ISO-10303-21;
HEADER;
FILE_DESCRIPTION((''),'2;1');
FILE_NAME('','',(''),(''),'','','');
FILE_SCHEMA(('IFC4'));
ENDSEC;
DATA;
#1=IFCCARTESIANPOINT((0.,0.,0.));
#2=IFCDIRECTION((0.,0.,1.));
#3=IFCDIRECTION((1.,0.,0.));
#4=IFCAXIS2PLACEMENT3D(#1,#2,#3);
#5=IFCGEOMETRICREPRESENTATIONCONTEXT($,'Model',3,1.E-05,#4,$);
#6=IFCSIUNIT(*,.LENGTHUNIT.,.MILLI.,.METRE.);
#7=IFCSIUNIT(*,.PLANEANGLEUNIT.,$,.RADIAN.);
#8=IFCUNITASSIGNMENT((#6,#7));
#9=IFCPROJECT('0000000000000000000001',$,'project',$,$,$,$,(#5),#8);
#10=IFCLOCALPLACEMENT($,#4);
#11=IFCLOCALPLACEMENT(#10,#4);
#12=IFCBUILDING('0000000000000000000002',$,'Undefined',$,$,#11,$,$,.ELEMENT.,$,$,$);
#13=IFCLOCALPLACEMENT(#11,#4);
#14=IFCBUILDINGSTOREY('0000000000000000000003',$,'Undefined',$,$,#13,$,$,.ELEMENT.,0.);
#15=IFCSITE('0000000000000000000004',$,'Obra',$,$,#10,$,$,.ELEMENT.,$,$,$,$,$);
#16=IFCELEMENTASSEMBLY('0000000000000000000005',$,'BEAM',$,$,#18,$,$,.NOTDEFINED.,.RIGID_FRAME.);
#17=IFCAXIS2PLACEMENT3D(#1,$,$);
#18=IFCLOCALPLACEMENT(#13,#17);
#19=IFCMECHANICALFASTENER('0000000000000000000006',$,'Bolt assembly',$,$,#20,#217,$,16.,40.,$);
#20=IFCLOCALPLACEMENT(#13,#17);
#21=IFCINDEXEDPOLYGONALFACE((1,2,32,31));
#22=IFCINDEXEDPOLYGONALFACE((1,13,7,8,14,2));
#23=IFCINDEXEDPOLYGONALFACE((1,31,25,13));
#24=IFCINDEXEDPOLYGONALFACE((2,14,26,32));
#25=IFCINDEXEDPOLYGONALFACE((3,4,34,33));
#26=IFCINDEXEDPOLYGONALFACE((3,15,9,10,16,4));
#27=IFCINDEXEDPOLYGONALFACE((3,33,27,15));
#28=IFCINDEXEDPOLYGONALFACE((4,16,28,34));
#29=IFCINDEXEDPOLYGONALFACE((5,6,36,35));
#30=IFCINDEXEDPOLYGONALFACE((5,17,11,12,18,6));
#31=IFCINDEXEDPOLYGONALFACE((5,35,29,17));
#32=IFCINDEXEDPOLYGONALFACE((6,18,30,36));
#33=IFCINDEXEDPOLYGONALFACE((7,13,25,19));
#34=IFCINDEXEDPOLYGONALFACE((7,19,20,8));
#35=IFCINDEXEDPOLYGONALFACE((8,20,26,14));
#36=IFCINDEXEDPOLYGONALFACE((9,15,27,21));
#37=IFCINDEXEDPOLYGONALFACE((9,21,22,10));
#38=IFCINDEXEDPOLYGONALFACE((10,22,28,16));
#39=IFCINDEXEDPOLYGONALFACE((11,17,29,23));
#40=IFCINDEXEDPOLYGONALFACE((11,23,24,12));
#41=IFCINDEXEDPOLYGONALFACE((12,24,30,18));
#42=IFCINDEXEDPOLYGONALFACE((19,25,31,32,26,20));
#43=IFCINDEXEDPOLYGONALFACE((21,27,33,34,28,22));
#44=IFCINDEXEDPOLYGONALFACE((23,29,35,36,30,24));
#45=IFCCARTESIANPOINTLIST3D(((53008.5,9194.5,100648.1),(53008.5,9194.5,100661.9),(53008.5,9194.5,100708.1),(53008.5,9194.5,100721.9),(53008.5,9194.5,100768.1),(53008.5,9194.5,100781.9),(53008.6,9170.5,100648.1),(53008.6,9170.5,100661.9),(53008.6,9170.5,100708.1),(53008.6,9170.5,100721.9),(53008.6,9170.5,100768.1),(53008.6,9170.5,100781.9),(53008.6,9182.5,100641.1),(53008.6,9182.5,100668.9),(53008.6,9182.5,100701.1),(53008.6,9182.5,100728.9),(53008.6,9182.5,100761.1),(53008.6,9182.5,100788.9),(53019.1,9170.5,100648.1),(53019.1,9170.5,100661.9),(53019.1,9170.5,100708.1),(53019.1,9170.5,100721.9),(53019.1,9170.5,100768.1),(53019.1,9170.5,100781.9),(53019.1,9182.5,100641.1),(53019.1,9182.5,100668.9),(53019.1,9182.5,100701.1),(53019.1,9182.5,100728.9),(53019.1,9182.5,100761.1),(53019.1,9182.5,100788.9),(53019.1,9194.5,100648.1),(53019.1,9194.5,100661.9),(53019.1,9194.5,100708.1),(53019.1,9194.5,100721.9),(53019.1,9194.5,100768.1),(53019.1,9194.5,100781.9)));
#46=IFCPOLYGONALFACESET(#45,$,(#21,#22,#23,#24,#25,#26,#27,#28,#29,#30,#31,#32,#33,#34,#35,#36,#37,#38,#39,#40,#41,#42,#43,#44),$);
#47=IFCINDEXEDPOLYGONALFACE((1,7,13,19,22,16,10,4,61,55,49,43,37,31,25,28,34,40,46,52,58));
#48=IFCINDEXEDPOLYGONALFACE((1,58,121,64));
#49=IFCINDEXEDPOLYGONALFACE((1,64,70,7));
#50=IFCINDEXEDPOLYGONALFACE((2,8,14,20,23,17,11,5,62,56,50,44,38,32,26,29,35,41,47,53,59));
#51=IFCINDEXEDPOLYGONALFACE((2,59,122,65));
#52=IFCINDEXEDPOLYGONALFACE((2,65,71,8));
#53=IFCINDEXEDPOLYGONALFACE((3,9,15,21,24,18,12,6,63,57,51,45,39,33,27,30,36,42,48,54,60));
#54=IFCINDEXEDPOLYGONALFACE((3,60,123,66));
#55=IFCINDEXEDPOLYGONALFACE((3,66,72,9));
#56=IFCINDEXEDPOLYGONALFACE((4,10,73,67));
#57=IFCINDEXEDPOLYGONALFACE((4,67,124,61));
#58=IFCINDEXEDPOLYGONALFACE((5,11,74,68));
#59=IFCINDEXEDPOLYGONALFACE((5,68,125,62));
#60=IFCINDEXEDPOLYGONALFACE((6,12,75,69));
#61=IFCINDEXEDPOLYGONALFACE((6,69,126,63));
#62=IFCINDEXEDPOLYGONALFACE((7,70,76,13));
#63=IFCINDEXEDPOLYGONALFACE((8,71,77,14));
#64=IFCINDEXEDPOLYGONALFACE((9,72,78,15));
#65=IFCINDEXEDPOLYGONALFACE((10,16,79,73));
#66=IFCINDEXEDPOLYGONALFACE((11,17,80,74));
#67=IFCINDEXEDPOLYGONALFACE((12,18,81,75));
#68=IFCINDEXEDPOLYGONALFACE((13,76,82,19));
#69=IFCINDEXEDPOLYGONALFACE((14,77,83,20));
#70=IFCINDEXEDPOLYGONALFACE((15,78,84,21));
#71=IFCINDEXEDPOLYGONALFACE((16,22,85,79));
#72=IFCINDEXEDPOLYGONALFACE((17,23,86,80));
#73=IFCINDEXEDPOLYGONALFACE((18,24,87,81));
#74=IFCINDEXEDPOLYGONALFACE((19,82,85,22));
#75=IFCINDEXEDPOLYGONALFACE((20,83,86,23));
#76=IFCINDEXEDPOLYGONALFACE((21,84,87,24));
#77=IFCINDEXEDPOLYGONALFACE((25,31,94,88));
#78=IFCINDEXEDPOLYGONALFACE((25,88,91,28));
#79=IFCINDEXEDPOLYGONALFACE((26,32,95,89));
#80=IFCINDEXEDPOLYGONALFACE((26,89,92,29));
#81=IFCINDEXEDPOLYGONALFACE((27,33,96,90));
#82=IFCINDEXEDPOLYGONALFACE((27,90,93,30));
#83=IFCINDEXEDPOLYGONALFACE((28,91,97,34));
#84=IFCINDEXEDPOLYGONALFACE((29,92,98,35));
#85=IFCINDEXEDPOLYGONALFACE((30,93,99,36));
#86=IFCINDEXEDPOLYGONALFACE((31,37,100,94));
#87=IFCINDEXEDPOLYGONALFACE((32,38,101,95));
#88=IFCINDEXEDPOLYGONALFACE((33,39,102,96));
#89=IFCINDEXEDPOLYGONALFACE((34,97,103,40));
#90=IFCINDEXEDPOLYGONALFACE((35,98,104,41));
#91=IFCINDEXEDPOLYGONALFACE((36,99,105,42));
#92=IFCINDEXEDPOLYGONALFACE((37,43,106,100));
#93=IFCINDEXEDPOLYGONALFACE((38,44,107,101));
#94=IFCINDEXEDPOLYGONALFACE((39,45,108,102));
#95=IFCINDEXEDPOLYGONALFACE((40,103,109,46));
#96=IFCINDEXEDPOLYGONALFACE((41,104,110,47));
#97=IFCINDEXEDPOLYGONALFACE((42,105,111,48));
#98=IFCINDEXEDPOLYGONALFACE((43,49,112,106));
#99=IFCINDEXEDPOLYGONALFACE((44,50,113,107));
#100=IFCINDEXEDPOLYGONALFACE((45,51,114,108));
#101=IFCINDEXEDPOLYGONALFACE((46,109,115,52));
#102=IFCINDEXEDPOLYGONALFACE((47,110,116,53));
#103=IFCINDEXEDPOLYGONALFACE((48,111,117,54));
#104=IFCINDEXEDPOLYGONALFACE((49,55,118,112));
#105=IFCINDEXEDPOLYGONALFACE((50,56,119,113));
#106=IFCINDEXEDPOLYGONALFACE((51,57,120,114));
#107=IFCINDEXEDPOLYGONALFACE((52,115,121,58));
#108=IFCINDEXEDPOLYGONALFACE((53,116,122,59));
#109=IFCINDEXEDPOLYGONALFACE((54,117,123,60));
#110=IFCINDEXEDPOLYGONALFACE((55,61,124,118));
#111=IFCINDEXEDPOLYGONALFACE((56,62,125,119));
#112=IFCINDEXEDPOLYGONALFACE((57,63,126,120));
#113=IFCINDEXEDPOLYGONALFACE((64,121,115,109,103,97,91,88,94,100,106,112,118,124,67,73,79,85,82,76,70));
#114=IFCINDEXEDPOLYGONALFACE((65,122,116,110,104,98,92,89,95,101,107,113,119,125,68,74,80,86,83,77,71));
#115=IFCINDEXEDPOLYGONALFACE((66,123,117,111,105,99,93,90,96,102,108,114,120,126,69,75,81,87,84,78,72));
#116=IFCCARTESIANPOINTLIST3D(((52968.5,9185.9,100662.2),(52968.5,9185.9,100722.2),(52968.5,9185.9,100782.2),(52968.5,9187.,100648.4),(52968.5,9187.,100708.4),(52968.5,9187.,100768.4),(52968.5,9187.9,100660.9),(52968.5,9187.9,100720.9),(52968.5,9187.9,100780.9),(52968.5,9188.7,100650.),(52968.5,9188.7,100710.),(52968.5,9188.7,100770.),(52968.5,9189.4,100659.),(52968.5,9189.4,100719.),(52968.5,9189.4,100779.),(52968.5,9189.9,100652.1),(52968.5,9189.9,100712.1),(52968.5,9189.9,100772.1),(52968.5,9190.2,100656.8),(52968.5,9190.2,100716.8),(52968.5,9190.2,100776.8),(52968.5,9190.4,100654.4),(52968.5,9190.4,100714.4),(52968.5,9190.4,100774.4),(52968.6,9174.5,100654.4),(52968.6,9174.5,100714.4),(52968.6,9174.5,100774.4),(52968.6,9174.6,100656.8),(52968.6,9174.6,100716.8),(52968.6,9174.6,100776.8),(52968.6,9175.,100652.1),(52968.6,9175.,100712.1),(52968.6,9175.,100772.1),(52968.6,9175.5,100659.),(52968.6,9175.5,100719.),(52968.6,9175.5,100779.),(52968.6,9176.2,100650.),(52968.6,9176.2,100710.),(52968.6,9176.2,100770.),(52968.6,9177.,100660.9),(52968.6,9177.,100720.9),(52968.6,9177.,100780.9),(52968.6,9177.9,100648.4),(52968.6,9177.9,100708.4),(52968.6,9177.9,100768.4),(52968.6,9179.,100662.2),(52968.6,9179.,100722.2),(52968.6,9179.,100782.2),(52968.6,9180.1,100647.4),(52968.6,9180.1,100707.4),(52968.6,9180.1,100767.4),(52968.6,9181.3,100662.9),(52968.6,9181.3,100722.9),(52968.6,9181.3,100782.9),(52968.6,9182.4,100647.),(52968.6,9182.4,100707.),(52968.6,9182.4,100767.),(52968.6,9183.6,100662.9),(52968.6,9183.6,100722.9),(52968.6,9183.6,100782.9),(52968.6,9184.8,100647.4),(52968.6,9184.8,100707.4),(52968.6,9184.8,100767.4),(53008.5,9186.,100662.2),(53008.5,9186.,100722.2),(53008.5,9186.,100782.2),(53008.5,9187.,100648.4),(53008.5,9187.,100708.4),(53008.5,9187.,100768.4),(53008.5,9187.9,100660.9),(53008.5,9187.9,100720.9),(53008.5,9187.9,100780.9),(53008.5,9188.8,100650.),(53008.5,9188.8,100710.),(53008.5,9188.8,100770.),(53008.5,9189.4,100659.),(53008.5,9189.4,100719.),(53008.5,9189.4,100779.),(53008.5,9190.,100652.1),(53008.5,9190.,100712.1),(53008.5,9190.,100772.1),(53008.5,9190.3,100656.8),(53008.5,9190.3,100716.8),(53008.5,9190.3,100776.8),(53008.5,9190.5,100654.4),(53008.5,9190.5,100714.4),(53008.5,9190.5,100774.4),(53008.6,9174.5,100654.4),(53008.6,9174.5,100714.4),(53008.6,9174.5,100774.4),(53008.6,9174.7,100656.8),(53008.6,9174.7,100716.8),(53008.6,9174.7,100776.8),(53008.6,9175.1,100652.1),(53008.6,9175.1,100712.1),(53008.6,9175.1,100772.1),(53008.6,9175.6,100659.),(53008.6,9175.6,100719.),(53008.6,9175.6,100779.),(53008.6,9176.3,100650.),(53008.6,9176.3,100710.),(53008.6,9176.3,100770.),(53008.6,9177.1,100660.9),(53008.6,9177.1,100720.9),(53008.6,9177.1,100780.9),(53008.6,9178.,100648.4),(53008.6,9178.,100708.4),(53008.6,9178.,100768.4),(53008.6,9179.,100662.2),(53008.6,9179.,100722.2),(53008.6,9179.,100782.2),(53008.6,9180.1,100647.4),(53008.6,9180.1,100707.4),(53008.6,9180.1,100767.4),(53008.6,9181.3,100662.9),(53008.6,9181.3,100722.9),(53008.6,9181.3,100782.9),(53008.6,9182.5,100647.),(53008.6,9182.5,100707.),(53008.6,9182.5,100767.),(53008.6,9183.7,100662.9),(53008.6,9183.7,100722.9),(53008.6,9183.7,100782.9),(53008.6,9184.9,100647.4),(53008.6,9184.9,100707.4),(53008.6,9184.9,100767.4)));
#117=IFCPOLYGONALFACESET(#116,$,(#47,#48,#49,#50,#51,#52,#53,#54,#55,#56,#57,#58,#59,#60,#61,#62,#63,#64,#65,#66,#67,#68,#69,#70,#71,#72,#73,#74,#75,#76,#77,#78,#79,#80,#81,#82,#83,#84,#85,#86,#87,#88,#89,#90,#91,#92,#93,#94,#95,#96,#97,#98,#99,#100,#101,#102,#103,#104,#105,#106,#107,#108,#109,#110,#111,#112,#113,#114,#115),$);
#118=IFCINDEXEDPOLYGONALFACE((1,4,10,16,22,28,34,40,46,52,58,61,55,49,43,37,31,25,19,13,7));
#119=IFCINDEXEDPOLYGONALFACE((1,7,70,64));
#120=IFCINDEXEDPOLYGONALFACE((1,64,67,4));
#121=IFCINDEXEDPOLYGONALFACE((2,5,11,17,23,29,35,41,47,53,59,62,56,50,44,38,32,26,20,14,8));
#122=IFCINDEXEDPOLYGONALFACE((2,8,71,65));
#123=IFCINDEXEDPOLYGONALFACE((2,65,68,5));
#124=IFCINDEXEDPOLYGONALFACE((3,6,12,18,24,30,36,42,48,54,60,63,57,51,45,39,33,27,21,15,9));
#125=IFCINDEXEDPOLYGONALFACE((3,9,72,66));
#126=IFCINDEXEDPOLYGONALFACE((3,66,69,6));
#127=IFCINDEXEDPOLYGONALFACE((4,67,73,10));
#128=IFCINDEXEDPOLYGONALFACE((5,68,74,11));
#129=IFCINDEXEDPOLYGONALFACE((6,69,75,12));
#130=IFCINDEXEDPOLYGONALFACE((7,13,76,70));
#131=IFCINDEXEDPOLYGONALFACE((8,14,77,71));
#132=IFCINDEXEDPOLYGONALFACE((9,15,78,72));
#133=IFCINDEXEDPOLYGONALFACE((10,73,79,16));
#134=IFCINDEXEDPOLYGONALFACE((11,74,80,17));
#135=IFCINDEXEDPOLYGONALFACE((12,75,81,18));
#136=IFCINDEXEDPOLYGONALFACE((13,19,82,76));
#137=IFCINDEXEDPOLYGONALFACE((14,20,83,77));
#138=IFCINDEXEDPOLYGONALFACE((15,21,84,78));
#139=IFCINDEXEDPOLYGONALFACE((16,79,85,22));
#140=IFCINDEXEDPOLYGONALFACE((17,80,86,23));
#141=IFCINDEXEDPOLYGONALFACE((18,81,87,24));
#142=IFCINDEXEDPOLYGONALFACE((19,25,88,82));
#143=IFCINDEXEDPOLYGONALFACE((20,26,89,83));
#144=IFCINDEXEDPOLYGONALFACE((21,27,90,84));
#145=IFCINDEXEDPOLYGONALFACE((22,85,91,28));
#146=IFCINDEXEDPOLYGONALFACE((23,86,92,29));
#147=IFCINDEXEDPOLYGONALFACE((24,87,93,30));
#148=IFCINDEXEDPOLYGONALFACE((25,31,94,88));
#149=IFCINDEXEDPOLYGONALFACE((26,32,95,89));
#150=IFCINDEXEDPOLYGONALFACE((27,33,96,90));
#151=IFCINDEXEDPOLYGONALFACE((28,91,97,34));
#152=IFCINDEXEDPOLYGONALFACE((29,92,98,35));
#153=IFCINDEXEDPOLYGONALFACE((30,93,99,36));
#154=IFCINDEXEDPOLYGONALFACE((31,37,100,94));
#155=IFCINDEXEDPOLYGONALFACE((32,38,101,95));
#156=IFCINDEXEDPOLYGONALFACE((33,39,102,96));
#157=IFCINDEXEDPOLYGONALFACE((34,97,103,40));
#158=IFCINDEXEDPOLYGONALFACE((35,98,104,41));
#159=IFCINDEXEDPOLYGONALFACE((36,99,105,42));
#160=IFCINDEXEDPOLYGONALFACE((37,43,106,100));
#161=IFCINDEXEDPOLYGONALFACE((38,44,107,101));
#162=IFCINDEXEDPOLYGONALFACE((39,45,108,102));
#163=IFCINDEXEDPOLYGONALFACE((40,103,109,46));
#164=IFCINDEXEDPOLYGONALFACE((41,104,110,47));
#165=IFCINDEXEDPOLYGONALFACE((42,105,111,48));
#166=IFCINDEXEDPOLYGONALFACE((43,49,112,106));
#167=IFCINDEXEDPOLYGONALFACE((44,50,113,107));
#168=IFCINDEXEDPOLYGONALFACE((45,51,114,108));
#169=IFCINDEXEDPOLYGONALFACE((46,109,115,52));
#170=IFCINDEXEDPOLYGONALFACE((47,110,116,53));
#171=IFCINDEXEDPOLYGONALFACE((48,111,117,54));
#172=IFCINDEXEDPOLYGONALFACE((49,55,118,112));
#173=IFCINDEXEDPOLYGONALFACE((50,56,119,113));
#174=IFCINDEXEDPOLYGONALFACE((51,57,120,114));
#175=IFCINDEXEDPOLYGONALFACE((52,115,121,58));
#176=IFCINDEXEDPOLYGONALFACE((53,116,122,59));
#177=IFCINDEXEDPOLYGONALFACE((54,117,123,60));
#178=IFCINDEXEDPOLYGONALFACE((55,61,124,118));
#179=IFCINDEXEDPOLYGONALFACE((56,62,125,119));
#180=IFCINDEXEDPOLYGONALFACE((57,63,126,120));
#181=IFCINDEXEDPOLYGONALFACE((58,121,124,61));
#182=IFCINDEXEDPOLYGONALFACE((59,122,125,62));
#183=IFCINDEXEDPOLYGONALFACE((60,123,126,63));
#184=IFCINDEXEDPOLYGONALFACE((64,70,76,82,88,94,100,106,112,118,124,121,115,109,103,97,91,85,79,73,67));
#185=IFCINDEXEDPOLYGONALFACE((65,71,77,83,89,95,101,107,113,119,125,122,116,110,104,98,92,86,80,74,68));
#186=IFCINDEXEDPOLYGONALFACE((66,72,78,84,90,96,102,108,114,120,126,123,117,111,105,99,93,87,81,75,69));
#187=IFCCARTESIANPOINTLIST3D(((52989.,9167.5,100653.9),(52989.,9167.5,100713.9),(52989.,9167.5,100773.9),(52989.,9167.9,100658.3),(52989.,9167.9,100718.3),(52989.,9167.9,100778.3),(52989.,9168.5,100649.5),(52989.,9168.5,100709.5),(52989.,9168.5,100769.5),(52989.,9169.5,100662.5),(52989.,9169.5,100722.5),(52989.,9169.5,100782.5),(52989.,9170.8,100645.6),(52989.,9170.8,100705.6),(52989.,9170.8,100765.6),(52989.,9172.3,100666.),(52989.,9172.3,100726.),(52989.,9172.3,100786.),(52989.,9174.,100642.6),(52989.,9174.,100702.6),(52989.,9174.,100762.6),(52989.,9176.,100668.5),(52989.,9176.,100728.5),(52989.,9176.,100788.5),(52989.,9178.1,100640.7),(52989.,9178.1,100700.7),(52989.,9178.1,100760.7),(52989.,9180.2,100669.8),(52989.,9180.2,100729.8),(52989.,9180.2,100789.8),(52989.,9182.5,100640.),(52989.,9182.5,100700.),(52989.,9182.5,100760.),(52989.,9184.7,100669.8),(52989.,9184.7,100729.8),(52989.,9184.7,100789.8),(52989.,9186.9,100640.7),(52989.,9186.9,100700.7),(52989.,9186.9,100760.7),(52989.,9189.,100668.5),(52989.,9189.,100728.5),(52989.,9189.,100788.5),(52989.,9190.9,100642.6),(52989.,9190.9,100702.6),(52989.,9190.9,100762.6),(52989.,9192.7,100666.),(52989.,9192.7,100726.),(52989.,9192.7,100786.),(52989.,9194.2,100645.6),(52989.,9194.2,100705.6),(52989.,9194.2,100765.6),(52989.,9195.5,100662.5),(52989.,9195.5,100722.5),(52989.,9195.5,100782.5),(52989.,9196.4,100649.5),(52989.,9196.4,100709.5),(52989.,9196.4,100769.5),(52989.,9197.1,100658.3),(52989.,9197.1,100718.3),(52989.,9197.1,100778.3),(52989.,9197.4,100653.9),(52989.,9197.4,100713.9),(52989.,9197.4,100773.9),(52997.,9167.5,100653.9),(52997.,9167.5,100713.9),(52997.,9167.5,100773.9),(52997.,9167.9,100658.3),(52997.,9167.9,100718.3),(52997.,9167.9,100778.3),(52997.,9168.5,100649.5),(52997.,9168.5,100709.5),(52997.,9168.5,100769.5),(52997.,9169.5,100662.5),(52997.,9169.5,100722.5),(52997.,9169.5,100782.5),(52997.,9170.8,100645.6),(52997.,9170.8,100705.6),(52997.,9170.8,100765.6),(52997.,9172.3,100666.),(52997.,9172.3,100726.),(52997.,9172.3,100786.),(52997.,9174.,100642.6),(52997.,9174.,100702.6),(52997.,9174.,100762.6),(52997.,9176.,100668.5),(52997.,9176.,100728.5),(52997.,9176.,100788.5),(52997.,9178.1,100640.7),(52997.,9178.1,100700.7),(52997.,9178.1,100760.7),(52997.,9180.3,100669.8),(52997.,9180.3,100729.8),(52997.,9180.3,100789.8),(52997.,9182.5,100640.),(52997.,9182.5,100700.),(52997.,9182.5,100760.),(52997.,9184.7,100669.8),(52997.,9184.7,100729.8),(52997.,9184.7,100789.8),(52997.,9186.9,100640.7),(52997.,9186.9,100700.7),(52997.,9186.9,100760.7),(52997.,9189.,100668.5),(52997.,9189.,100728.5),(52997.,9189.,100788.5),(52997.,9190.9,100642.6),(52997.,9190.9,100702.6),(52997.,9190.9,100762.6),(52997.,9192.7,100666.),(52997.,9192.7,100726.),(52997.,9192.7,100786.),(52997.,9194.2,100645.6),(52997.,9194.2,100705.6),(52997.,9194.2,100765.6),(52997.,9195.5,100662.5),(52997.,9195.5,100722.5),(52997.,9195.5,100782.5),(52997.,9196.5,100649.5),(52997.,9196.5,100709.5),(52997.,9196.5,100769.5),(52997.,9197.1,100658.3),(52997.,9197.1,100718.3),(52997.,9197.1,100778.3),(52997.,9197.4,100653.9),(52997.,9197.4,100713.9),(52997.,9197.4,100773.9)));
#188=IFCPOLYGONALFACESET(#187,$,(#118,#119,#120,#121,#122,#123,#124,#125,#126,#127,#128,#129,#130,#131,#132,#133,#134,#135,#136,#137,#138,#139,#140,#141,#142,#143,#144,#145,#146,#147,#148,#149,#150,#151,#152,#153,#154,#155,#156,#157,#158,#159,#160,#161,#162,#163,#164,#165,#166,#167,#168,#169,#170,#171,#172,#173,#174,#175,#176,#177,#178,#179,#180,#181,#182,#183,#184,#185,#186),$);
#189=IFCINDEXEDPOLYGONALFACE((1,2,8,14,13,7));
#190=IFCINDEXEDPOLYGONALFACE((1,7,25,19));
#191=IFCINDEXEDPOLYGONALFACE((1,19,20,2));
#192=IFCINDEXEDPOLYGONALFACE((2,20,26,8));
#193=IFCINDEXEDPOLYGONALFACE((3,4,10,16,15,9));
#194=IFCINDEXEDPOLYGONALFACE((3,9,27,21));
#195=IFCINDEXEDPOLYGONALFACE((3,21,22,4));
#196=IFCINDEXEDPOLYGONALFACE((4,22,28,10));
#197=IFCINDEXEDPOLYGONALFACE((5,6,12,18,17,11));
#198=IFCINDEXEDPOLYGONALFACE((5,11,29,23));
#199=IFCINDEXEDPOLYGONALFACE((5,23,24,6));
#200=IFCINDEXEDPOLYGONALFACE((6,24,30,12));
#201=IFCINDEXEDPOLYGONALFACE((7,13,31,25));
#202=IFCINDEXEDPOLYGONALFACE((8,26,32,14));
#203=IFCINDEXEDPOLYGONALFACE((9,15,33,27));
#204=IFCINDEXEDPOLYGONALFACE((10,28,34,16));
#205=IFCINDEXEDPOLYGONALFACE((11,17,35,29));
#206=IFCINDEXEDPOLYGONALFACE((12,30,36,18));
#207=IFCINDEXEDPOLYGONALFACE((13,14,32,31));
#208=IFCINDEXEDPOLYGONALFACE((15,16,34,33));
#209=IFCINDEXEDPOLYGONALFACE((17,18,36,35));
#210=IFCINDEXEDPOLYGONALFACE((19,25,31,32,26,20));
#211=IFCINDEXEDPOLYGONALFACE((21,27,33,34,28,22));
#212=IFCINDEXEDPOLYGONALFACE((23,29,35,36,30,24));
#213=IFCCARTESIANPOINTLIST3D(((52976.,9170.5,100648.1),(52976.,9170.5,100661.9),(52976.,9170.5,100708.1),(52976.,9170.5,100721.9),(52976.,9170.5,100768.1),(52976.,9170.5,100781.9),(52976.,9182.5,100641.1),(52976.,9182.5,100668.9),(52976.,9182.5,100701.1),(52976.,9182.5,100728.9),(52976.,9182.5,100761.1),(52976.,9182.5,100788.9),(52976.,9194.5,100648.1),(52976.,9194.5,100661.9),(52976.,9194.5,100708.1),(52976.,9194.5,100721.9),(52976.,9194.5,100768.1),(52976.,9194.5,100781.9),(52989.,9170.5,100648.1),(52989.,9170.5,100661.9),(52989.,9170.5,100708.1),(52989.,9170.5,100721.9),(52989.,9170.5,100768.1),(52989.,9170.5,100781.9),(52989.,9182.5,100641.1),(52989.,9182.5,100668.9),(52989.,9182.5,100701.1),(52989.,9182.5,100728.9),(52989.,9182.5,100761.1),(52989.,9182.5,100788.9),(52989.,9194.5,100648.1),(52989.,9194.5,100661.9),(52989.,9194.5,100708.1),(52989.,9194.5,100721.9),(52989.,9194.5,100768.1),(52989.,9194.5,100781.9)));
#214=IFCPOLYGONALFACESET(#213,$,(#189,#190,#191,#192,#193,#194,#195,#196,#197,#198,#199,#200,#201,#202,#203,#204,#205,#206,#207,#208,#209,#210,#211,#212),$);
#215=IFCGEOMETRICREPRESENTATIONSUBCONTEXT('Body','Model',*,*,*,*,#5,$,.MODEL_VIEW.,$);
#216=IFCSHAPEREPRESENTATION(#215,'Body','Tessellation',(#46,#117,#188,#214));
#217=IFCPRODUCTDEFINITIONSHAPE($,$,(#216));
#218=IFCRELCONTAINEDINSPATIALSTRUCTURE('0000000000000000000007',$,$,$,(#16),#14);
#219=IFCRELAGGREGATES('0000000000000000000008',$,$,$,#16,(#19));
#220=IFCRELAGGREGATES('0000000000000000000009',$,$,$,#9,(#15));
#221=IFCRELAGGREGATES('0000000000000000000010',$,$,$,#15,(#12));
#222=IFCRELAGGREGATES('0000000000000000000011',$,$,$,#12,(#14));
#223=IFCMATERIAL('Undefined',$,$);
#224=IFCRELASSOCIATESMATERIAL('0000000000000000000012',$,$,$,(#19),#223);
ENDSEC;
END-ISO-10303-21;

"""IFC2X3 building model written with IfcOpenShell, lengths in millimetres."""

from ifc_helpers import new_model, si_unit, frame, origin_with_axes, origin_2d_with_axis, place, context, subcontext, project, spatial, polyline, circle, outline, extrude, source, transform, mapped, material, element, aggregate, save


model = new_model("IFC2X3")

# Units and contexts
model_context = context("Model", 3, precision=1e-05, world=origin_with_axes())
body_context = subcontext(model_context, "Body", "Model", "MODEL_VIEW")
ifc_project = project(units=[si_unit("LENGTHUNIT", "METRE", prefix="MILLI"), si_unit("PLANEANGLEUNIT", "RADIAN")], contexts=[model_context])

# Site, building, storey
site_placement = place(None, origin_with_axes())
site = spatial("IfcSite", under=ifc_project, at=site_placement, Name="Obra", CompositionType="ELEMENT")
building_placement = place(site_placement, origin_with_axes())
building = spatial("IfcBuilding", under=site, at=building_placement, Name="Undefined", CompositionType="ELEMENT")
storey_placement = place(building_placement, origin_with_axes())
storey = spatial("IfcBuildingStorey", under=building, at=storey_placement, Name="Undefined", CompositionType="ELEMENT", Elevation=0.0)

# Element assembly, mechanical fastener
assembly_1_placement = place(storey_placement, origin_with_axes())
assembly_1 = element("IfcElementAssembly", 1, at=assembly_1_placement, inside=storey, Name="BEAM", AssemblyPlace="NOTDEFINED", PredefinedType="RIGID_FRAME")
ifc_material_1 = material(Name="Undefined")
shared_shape_1 = source(origin_with_axes(), body_context, "Body", "SweptSolid", [
    extrude(outline(polyline([(13.9, 0.0), (6.9, 12.0), (-6.9, 12.0), (-13.9, 0.0), (-6.9, -12.0), (6.9, -12.0), (13.9, 0.0)])), frame((0.0, -19.7, 0.0), z_axis=(0.0, 1.0, 0.0), x_axis=(1.0, 0.0, 0.0)), (0.0, 0.0, 1.0), 10.6),
    extrude(circle(Radius=8.0, at=origin_2d_with_axis()), frame((0.0, -9.1, 0.0), z_axis=(0.0, 1.0, 0.0), x_axis=(1.0, 0.0, 0.0)), (0.0, 0.0, 1.0), 40.0),
    extrude(circle(Radius=15.0, at=origin_2d_with_axis()), frame((0.0, 2.5, 0.0), z_axis=(0.0, 1.0, 0.0), x_axis=(1.0, 0.0, 0.0)), (0.0, 0.0, 1.0), 8.0),
    extrude(outline(polyline([(13.9, 0.0), (6.9, 12.0), (-6.9, 12.0), (-13.9, 0.0), (-6.9, -12.0), (6.9, -12.0), (13.9, 0.0)])), frame((0.0, 10.5, 0.0), z_axis=(0.0, 1.0, 0.0), x_axis=(1.0, 0.0, 0.0)), (0.0, 0.0, 1.0), 13.0),
])
mechanical_fastener_1_placement = place(assembly_1_placement, frame((52999.5, 9132.5, 100835.0), z_axis=(-0.001508, 0.999999, 0.0), x_axis=(0.0, 0.0, -1.0)))
mechanical_fastener_1 = element("IfcMechanicalFastener", 2, at=mechanical_fastener_1_placement, material=ifc_material_1, Name="Bolt assembly", NominalDiameter=16.0, NominalLength=40.0, context=body_context, shape_type="MappedRepresentation", body=[
    mapped(shared_shape_1, transform((60.0, 0.0, 50.0))),
    mapped(shared_shape_1, transform((120.0, 0.0, 50.0))),
    mapped(shared_shape_1, transform((180.0, 0.0, 50.0))),
])
aggregate(assembly_1, [mechanical_fastener_1])

save(model, "model.ifc")
